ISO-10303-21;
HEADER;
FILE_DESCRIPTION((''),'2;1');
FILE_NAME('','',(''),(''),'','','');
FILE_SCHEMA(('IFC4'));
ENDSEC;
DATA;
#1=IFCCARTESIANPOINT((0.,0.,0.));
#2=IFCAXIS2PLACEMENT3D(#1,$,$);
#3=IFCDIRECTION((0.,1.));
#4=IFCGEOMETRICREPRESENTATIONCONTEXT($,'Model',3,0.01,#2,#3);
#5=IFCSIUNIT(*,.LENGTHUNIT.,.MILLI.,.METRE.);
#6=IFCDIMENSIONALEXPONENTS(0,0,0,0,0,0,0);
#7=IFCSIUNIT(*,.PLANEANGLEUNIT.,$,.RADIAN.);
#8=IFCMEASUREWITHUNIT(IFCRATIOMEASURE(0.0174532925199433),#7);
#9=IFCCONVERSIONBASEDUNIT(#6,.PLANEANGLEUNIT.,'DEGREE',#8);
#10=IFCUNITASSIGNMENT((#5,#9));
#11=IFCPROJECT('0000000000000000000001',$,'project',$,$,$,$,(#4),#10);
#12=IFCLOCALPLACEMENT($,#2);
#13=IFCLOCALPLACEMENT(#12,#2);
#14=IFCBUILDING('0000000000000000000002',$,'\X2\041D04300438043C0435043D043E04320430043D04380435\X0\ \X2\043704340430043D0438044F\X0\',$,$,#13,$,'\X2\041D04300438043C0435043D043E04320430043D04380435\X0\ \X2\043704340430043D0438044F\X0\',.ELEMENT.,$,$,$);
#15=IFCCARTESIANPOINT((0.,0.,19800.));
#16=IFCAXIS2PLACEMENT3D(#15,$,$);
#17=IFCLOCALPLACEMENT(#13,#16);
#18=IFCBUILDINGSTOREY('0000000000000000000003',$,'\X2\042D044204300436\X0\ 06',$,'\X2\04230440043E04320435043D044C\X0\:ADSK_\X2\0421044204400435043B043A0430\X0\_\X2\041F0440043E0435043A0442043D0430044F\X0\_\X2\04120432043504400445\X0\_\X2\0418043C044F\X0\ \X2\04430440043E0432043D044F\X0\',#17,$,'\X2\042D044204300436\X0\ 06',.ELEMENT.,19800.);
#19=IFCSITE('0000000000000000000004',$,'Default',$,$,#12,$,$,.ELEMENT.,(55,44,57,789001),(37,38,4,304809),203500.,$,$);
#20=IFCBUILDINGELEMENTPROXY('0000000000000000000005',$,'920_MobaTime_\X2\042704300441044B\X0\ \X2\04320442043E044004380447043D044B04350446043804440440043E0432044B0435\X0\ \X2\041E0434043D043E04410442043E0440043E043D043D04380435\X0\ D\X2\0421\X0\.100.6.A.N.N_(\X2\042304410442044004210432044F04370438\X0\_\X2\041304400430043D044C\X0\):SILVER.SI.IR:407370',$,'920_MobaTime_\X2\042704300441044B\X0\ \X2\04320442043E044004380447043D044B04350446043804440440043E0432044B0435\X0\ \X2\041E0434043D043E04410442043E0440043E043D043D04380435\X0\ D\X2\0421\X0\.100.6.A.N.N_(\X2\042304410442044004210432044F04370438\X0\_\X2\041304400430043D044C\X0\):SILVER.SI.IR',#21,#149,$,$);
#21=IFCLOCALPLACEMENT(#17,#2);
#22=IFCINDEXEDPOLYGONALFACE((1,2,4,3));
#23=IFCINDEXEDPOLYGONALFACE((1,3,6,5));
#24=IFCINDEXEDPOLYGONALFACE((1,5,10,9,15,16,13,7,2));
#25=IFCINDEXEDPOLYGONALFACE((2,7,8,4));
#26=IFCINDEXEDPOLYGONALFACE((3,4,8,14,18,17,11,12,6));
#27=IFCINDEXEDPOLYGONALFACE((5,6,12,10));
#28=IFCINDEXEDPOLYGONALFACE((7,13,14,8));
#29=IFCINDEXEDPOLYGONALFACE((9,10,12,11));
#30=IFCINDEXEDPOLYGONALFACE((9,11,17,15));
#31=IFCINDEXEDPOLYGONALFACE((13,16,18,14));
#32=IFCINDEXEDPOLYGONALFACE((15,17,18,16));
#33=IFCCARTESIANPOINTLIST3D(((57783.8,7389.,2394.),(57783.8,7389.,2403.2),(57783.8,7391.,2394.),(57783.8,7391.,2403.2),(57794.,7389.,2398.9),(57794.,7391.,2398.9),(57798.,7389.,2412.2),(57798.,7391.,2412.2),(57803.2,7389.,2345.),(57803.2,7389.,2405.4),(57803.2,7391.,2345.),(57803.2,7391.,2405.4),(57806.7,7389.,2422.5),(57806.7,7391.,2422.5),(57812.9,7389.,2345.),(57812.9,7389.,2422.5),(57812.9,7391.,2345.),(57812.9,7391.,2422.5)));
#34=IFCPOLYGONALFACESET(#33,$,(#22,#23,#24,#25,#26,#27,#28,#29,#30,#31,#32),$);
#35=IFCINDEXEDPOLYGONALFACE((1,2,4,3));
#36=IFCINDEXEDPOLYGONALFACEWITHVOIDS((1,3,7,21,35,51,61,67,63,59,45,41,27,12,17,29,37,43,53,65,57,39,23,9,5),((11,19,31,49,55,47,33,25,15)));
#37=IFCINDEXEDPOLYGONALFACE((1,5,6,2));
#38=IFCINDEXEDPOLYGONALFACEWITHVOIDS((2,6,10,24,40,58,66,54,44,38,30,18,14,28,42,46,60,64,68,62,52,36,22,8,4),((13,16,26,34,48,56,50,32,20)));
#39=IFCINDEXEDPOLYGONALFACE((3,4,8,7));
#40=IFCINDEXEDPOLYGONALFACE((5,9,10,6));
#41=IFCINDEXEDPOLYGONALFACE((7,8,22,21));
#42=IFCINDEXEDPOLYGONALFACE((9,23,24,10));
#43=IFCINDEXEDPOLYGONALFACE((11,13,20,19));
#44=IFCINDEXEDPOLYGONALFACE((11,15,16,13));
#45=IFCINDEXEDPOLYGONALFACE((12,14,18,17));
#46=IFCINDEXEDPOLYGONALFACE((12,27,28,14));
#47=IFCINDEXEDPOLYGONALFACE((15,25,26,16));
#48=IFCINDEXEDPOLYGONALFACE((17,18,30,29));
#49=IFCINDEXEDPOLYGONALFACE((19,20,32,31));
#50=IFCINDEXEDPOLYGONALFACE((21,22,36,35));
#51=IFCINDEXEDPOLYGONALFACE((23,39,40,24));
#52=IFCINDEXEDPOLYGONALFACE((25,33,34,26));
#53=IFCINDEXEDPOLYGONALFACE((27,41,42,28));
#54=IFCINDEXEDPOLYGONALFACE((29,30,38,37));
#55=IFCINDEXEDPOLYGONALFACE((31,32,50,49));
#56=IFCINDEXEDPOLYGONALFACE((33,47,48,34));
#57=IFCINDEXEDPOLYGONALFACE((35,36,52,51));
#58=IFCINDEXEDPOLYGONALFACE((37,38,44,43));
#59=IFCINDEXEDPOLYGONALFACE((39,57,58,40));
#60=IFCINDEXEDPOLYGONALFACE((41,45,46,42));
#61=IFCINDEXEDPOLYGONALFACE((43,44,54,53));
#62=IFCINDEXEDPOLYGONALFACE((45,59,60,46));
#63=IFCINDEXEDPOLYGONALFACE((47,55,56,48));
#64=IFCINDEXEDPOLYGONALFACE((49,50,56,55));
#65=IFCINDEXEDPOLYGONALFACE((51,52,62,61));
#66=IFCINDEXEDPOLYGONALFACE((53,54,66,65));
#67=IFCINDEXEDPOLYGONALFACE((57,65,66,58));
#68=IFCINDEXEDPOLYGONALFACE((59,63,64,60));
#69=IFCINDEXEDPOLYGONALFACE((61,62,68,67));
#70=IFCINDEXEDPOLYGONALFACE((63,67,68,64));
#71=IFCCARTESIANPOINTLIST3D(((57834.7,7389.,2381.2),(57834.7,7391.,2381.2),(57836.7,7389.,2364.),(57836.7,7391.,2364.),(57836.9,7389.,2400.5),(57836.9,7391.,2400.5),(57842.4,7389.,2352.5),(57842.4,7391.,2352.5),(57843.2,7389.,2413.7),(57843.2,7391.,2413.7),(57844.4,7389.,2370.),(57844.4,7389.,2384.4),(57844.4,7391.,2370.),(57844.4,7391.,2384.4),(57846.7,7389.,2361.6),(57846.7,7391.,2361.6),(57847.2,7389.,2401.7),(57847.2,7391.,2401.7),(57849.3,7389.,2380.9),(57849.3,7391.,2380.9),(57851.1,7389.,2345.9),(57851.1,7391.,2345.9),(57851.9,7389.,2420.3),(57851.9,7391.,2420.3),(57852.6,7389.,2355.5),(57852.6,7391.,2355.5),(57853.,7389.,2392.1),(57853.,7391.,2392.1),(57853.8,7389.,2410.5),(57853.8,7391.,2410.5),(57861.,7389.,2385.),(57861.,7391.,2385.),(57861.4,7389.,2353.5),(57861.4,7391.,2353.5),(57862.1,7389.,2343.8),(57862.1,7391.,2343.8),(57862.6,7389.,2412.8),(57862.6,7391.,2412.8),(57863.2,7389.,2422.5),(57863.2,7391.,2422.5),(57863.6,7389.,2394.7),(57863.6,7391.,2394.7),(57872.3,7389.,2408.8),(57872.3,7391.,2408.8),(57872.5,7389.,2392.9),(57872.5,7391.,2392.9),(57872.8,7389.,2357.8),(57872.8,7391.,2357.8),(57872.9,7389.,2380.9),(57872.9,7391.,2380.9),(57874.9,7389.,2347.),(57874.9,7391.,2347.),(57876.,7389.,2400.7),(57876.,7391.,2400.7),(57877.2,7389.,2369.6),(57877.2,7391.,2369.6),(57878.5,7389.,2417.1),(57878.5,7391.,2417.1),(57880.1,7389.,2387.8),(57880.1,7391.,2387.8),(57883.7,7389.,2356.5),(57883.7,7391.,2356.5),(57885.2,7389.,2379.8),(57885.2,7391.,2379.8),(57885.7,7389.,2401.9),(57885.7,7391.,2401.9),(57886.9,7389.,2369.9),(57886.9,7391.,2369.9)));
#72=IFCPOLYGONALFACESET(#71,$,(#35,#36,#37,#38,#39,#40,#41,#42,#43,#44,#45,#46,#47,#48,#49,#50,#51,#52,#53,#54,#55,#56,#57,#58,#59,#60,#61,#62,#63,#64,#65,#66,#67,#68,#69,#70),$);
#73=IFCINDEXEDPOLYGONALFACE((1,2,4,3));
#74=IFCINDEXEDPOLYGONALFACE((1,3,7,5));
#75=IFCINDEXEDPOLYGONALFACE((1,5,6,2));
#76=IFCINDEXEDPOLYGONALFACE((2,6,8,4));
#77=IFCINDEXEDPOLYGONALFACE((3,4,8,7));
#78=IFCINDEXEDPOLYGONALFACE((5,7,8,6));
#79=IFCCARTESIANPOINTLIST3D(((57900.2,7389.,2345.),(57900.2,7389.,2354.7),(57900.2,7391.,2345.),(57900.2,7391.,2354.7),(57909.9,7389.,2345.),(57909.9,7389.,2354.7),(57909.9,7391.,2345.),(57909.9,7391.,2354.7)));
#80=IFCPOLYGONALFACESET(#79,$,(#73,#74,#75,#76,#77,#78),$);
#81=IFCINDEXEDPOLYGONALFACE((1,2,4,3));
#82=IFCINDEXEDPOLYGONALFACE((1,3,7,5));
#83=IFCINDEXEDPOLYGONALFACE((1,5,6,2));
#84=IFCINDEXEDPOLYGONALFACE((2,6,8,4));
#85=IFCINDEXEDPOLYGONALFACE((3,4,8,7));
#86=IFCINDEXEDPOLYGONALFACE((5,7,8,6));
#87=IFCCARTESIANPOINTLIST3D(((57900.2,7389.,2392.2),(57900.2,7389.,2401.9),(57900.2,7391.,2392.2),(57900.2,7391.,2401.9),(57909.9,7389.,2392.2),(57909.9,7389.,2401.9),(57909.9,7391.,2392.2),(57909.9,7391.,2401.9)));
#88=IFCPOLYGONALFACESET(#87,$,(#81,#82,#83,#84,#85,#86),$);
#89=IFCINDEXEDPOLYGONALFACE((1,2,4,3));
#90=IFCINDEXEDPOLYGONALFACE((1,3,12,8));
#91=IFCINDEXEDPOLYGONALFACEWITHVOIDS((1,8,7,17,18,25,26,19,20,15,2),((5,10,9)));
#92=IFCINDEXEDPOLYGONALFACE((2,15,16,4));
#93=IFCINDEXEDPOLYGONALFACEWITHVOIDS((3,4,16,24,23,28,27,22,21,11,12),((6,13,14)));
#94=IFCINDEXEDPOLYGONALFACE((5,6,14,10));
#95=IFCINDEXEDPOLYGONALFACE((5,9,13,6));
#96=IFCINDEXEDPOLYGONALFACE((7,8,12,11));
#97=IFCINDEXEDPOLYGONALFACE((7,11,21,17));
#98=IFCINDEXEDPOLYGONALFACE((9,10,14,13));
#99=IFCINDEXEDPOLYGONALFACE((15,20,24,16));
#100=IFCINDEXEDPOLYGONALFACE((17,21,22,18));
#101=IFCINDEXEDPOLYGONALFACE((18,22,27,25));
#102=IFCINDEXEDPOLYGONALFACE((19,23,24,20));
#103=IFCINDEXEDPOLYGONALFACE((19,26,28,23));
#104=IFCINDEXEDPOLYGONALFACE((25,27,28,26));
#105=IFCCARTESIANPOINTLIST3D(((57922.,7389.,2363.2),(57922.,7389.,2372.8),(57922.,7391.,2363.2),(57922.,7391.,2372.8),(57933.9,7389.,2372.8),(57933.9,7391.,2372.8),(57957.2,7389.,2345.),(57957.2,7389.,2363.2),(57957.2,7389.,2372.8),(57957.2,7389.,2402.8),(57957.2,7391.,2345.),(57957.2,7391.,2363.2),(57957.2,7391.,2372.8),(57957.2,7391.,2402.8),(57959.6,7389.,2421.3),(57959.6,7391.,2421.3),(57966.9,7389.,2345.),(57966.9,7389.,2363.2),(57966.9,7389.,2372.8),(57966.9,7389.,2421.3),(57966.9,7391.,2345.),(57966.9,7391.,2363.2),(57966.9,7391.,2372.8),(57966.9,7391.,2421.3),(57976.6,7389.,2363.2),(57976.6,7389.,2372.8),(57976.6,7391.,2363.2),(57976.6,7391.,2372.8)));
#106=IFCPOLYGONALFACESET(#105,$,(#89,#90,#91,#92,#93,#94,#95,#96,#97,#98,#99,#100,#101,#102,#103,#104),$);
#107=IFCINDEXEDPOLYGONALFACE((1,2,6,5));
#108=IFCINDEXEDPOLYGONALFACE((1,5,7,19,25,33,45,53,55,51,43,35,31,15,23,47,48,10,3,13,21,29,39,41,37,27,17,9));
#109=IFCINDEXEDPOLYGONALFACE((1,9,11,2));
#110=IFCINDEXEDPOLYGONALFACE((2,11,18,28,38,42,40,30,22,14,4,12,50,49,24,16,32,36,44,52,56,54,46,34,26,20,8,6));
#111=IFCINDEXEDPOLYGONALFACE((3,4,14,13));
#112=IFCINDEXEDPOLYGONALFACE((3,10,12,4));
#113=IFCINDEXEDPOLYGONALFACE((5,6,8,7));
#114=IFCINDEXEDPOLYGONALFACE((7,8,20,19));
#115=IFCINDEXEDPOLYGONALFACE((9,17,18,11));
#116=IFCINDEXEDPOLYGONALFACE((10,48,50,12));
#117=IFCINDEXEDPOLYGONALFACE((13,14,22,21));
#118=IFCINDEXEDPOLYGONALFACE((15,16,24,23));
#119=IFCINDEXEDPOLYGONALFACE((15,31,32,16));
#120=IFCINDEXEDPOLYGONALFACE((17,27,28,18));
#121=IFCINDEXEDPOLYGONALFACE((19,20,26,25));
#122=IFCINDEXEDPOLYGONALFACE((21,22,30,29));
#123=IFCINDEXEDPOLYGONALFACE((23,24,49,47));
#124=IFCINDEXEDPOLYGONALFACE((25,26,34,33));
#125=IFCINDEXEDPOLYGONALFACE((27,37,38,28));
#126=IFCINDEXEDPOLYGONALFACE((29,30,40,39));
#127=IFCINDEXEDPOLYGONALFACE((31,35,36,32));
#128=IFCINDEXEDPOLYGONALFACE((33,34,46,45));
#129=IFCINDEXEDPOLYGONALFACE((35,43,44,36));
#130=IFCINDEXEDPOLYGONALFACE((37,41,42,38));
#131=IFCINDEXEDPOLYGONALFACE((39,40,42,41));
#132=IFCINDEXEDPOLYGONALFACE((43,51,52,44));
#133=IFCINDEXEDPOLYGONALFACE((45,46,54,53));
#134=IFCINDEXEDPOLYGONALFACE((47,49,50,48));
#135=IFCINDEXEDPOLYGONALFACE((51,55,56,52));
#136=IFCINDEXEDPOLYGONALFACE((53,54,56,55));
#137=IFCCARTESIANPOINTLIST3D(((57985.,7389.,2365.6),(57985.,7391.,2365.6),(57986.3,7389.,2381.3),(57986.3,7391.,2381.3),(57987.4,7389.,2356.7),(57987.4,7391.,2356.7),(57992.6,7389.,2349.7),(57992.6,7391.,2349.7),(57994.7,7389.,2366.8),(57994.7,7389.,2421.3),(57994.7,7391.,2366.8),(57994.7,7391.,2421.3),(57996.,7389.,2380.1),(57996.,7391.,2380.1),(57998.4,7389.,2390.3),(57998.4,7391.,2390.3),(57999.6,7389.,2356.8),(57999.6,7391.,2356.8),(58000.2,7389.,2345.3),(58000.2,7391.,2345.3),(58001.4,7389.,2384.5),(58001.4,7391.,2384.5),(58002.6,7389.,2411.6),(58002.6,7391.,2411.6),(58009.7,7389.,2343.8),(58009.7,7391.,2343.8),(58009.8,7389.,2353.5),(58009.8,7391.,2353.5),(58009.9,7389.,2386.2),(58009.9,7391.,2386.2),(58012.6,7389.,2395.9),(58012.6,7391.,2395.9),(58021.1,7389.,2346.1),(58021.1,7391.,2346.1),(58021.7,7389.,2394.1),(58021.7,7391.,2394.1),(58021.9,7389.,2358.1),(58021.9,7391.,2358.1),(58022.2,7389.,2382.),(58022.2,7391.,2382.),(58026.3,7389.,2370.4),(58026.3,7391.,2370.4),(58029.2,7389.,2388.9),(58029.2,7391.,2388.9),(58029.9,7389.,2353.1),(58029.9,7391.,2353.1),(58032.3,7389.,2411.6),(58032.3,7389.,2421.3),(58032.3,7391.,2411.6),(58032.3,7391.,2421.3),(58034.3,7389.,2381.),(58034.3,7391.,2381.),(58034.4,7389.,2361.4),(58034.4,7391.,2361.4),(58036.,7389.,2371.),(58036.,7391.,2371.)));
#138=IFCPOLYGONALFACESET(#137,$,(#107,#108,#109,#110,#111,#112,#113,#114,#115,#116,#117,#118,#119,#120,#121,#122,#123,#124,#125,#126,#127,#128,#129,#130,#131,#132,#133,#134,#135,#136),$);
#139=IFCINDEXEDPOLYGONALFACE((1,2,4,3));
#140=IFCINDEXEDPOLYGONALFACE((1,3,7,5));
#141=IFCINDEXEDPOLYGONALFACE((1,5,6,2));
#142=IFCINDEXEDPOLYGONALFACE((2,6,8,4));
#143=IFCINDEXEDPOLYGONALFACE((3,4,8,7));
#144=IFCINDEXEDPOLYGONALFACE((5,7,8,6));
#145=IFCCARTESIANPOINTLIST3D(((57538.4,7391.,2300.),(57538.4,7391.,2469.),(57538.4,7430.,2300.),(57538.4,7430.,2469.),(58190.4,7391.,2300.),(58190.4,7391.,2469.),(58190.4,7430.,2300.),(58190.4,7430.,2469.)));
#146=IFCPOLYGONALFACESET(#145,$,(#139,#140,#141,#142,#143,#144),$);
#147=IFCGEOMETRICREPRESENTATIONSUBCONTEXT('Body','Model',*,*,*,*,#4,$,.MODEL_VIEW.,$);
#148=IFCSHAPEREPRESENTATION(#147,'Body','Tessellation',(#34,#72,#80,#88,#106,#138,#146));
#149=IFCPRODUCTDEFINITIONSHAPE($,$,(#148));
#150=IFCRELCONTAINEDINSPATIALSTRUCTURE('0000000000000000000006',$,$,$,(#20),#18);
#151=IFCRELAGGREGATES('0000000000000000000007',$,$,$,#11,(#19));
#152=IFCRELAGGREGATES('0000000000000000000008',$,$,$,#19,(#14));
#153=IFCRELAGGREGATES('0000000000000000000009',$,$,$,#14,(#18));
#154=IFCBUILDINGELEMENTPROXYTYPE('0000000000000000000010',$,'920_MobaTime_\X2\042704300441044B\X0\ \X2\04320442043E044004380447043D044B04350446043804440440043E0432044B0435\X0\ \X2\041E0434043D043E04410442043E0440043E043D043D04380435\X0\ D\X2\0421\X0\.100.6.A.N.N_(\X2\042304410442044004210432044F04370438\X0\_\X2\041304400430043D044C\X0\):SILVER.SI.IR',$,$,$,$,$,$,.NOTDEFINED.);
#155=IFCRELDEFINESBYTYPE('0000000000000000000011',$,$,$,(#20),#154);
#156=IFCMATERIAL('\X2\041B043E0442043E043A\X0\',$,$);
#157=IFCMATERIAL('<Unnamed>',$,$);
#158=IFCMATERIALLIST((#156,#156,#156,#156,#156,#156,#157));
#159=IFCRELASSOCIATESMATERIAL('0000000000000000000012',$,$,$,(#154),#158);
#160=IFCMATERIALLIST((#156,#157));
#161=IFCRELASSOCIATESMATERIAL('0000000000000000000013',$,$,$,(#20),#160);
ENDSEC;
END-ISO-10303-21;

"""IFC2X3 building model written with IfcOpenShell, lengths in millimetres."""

from ifc_helpers import new_model, entity, si_unit, converted_unit, direction, frame, origin, origin_2d_with_axis, place, context, subcontext, project, spatial, polyline, rectangle, outline, extrude, source, transform, mapped, material, material_list, type_object, type_shapes, element, save


model = new_model("IFC2X3")

# Units and contexts
model_context = context("Model", 3, precision=0.01, world=origin(), true_north=direction((0.0, 1.0)))
body_context = subcontext(model_context, "Body", "Model", "MODEL_VIEW")
ifc_project = project(units=[si_unit("LENGTHUNIT", "METRE", prefix="MILLI"), converted_unit("PLANEANGLEUNIT", "DEGREE", entity("IfcRatioMeasure", 0.0174532925199433), si_unit("PLANEANGLEUNIT", "RADIAN"), dimensions=[0, 0, 0, 0, 0, 0, 0])], contexts=[model_context])

# Site, building, storey
site_placement = place(None, frame((0.0, 0.0, 0.0)))
site = spatial("IfcSite", under=ifc_project, at=site_placement, Name="Default", CompositionType="ELEMENT", RefLatitude=(55, 44, 57, 789001), RefLongitude=(37, 38, 4, 304809), RefElevation=203500.0)
building_placement = place(site_placement, origin())
building = spatial("IfcBuilding", under=site, at=building_placement, Name="Наименование здания", LongName="Наименование здания", CompositionType="ELEMENT")
storey_placement = place(building_placement, frame((0.0, 0.0, 19800.0)))
storey = spatial("IfcBuildingStorey", under=building, at=storey_placement, Name="Этаж 06", ObjectType="Уровень:ADSK_Стрелка_Проектная_Вверх_Имя уровня", LongName="Этаж 06", CompositionType="ELEMENT", Elevation=19800.0)

# Building element proxy
ifc_material_1 = material(Name="Лоток")
ifc_material_2 = material(Name="<Unnamed>")
ifc_material_list_1 = material_list([ifc_material_1, ifc_material_1, ifc_material_1, ifc_material_1, ifc_material_1, ifc_material_1, ifc_material_2])
building_element_proxy_type_1 = type_object("IfcBuildingElementProxyType", Name="920_MobaTime_Часы вторичныецифровые Односторонние DС.100.6.A.N.N_(УстрСвязи_Грань):SILVER.SI.IR", PredefinedType="NOTDEFINED", material=ifc_material_list_1)
shared_shape_1 = source(origin(), body_context, "Body", "SweptSolid", [
    extrude(outline(polyline([(-49.3, -13.1), (28.2, -13.1), (28.2, -6.8), (17.9, 1.8), (8.9, 16.0), (-0.3, 16.0), (4.6, 5.8), (11.1, -3.4), (-49.3, -3.4), (-49.3, -13.1)])), frame((-64.6, 9.8, 39.0), z_axis=(0.0, 0.0, 1.0), x_axis=(0.0, 1.0, 0.0)), (0.0, 0.0, 1.0), 2.0),
    extrude(outline(polyline([(2.2, -27.6), (19.0, -27.6), (30.5, -16.1), (33.3, -4.9), (31.0, 5.8), (21.8, 17.2), (5.2, 27.3), (-11.1, 33.0), (-24.0, 32.7), (-33.6, 27.6), (-40.3, 18.6), (-42.8, 5.7), (-38.0, -6.3), (-27.2, -15.0), (-17.5, -17.7), (-8.2, -16.4), (-0.3, -11.9), (5.1, -4.5), (7.3, 6.2), (4.0, 17.2), (18.5, 7.3), (23.6, -2.4), (22.0, -11.4), (14.2, -18.4), (5.3, -18.3), (2.2, -27.6)]), holes=[polyline([(-9.0, 23.3), (-1.3, 14.4), (-2.6, 2.0), (-11.4, -7.0), (-23.4, -6.1), (-32.2, 2.9), (-31.2, 15.1), (-25.6, 22.1), (-17.5, 24.9), (-9.0, 23.3)])]), frame((-2.7, 3.6, 39.0), z_axis=(0.0, 0.0, 1.0), x_axis=(-0.427649, 0.903945, 0.0)), (0.0, 0.0, 1.0), 2.0),
    extrude(rectangle(XDim=9.7, YDim=9.7, at=origin_2d_with_axis()), frame((40.6, -34.7, 39.0)), (0.0, 0.0, 1.0), 2.0),
    extrude(rectangle(XDim=9.7, YDim=9.7, at=origin_2d_with_axis()), frame((40.6, 12.6, 39.0)), (0.0, 0.0, 1.0), 2.0),
    extrude(outline(polyline([(-0.9, -28.1), (8.8, -28.1), (8.8, -9.9), (18.5, -9.9), (18.5, -0.2), (8.8, -0.2), (8.8, 48.3), (1.5, 48.3), (-36.0, -0.2), (-36.0, -9.9), (-0.9, -9.9), (-0.9, -28.1)]), holes=[polyline([(-0.9, -0.2), (-24.1, -0.2), (-0.9, 29.7), (-0.9, -0.2)])]), frame((93.6, -11.4, 39.0)), (0.0, 0.0, 1.0), 2.0),
    extrude(outline(polyline([(3.3, -28.3), (12.5, -28.3), (20.5, -25.0), (26.8, -18.8), (30.7, -10.0), (31.4, 1.6), (26.9, 11.8), (20.1, 18.4), (11.1, 22.3), (1.0, 23.3), (-7.9, 20.4), (-14.9, 14.5), (-18.9, 6.2), (-17.1, -9.0), (-36.7, 0.5), (-29.1, 29.3), (-38.5, 31.7), (-48.1, -4.6), (-11.6, -23.0), (-8.0, -14.0), (-10.8, -7.6), (-10.2, 1.1), (-3.0, 11.8), (9.2, 12.8), (20.0, 5.4), (21.3, -7.5), (15.5, -16.4), (4.6, -18.6), (3.3, -28.3)])), frame((147.1, -8.5, 39.0), z_axis=(0.0, 0.0, 1.0), x_axis=(0.256974, -0.966418, 0.0)), (0.0, 0.0, 1.0), 2.0),
    extrude(rectangle(XDim=652.0, YDim=169.0, at=origin_2d_with_axis()), frame((0.0, 0.0, 0.0), z_axis=(0.0, 0.0, 1.0), x_axis=(-1.0, 0.0, 0.0)), (0.0, 0.0, 1.0), 39.0),
])
type_shapes(building_element_proxy_type_1, [shared_shape_1])
ifc_material_list_2 = material_list([ifc_material_1, ifc_material_2])
proxy_1_placement = place(storey_placement, frame((57864.4, 7430.0, 2384.5), z_axis=(0.0, -1.0, 0.0), x_axis=(1.0, 0.0, 0.0)))
element("IfcBuildingElementProxy", 1, at=proxy_1_placement, inside=storey, type_object=building_element_proxy_type_1, material=ifc_material_list_2, Name="920_MobaTime_Часы вторичныецифровые Односторонние DС.100.6.A.N.N_(УстрСвязи_Грань):SILVER.SI.IR:407370", ObjectType="920_MobaTime_Часы вторичныецифровые Односторонние DС.100.6.A.N.N_(УстрСвязи_Грань):SILVER.SI.IR", context=body_context, shape_type="MappedRepresentation", body=[
    mapped(shared_shape_1, transform((0.0, 0.0, 0.0), scale=1.0)),
])

save(model, "model.ifc")
